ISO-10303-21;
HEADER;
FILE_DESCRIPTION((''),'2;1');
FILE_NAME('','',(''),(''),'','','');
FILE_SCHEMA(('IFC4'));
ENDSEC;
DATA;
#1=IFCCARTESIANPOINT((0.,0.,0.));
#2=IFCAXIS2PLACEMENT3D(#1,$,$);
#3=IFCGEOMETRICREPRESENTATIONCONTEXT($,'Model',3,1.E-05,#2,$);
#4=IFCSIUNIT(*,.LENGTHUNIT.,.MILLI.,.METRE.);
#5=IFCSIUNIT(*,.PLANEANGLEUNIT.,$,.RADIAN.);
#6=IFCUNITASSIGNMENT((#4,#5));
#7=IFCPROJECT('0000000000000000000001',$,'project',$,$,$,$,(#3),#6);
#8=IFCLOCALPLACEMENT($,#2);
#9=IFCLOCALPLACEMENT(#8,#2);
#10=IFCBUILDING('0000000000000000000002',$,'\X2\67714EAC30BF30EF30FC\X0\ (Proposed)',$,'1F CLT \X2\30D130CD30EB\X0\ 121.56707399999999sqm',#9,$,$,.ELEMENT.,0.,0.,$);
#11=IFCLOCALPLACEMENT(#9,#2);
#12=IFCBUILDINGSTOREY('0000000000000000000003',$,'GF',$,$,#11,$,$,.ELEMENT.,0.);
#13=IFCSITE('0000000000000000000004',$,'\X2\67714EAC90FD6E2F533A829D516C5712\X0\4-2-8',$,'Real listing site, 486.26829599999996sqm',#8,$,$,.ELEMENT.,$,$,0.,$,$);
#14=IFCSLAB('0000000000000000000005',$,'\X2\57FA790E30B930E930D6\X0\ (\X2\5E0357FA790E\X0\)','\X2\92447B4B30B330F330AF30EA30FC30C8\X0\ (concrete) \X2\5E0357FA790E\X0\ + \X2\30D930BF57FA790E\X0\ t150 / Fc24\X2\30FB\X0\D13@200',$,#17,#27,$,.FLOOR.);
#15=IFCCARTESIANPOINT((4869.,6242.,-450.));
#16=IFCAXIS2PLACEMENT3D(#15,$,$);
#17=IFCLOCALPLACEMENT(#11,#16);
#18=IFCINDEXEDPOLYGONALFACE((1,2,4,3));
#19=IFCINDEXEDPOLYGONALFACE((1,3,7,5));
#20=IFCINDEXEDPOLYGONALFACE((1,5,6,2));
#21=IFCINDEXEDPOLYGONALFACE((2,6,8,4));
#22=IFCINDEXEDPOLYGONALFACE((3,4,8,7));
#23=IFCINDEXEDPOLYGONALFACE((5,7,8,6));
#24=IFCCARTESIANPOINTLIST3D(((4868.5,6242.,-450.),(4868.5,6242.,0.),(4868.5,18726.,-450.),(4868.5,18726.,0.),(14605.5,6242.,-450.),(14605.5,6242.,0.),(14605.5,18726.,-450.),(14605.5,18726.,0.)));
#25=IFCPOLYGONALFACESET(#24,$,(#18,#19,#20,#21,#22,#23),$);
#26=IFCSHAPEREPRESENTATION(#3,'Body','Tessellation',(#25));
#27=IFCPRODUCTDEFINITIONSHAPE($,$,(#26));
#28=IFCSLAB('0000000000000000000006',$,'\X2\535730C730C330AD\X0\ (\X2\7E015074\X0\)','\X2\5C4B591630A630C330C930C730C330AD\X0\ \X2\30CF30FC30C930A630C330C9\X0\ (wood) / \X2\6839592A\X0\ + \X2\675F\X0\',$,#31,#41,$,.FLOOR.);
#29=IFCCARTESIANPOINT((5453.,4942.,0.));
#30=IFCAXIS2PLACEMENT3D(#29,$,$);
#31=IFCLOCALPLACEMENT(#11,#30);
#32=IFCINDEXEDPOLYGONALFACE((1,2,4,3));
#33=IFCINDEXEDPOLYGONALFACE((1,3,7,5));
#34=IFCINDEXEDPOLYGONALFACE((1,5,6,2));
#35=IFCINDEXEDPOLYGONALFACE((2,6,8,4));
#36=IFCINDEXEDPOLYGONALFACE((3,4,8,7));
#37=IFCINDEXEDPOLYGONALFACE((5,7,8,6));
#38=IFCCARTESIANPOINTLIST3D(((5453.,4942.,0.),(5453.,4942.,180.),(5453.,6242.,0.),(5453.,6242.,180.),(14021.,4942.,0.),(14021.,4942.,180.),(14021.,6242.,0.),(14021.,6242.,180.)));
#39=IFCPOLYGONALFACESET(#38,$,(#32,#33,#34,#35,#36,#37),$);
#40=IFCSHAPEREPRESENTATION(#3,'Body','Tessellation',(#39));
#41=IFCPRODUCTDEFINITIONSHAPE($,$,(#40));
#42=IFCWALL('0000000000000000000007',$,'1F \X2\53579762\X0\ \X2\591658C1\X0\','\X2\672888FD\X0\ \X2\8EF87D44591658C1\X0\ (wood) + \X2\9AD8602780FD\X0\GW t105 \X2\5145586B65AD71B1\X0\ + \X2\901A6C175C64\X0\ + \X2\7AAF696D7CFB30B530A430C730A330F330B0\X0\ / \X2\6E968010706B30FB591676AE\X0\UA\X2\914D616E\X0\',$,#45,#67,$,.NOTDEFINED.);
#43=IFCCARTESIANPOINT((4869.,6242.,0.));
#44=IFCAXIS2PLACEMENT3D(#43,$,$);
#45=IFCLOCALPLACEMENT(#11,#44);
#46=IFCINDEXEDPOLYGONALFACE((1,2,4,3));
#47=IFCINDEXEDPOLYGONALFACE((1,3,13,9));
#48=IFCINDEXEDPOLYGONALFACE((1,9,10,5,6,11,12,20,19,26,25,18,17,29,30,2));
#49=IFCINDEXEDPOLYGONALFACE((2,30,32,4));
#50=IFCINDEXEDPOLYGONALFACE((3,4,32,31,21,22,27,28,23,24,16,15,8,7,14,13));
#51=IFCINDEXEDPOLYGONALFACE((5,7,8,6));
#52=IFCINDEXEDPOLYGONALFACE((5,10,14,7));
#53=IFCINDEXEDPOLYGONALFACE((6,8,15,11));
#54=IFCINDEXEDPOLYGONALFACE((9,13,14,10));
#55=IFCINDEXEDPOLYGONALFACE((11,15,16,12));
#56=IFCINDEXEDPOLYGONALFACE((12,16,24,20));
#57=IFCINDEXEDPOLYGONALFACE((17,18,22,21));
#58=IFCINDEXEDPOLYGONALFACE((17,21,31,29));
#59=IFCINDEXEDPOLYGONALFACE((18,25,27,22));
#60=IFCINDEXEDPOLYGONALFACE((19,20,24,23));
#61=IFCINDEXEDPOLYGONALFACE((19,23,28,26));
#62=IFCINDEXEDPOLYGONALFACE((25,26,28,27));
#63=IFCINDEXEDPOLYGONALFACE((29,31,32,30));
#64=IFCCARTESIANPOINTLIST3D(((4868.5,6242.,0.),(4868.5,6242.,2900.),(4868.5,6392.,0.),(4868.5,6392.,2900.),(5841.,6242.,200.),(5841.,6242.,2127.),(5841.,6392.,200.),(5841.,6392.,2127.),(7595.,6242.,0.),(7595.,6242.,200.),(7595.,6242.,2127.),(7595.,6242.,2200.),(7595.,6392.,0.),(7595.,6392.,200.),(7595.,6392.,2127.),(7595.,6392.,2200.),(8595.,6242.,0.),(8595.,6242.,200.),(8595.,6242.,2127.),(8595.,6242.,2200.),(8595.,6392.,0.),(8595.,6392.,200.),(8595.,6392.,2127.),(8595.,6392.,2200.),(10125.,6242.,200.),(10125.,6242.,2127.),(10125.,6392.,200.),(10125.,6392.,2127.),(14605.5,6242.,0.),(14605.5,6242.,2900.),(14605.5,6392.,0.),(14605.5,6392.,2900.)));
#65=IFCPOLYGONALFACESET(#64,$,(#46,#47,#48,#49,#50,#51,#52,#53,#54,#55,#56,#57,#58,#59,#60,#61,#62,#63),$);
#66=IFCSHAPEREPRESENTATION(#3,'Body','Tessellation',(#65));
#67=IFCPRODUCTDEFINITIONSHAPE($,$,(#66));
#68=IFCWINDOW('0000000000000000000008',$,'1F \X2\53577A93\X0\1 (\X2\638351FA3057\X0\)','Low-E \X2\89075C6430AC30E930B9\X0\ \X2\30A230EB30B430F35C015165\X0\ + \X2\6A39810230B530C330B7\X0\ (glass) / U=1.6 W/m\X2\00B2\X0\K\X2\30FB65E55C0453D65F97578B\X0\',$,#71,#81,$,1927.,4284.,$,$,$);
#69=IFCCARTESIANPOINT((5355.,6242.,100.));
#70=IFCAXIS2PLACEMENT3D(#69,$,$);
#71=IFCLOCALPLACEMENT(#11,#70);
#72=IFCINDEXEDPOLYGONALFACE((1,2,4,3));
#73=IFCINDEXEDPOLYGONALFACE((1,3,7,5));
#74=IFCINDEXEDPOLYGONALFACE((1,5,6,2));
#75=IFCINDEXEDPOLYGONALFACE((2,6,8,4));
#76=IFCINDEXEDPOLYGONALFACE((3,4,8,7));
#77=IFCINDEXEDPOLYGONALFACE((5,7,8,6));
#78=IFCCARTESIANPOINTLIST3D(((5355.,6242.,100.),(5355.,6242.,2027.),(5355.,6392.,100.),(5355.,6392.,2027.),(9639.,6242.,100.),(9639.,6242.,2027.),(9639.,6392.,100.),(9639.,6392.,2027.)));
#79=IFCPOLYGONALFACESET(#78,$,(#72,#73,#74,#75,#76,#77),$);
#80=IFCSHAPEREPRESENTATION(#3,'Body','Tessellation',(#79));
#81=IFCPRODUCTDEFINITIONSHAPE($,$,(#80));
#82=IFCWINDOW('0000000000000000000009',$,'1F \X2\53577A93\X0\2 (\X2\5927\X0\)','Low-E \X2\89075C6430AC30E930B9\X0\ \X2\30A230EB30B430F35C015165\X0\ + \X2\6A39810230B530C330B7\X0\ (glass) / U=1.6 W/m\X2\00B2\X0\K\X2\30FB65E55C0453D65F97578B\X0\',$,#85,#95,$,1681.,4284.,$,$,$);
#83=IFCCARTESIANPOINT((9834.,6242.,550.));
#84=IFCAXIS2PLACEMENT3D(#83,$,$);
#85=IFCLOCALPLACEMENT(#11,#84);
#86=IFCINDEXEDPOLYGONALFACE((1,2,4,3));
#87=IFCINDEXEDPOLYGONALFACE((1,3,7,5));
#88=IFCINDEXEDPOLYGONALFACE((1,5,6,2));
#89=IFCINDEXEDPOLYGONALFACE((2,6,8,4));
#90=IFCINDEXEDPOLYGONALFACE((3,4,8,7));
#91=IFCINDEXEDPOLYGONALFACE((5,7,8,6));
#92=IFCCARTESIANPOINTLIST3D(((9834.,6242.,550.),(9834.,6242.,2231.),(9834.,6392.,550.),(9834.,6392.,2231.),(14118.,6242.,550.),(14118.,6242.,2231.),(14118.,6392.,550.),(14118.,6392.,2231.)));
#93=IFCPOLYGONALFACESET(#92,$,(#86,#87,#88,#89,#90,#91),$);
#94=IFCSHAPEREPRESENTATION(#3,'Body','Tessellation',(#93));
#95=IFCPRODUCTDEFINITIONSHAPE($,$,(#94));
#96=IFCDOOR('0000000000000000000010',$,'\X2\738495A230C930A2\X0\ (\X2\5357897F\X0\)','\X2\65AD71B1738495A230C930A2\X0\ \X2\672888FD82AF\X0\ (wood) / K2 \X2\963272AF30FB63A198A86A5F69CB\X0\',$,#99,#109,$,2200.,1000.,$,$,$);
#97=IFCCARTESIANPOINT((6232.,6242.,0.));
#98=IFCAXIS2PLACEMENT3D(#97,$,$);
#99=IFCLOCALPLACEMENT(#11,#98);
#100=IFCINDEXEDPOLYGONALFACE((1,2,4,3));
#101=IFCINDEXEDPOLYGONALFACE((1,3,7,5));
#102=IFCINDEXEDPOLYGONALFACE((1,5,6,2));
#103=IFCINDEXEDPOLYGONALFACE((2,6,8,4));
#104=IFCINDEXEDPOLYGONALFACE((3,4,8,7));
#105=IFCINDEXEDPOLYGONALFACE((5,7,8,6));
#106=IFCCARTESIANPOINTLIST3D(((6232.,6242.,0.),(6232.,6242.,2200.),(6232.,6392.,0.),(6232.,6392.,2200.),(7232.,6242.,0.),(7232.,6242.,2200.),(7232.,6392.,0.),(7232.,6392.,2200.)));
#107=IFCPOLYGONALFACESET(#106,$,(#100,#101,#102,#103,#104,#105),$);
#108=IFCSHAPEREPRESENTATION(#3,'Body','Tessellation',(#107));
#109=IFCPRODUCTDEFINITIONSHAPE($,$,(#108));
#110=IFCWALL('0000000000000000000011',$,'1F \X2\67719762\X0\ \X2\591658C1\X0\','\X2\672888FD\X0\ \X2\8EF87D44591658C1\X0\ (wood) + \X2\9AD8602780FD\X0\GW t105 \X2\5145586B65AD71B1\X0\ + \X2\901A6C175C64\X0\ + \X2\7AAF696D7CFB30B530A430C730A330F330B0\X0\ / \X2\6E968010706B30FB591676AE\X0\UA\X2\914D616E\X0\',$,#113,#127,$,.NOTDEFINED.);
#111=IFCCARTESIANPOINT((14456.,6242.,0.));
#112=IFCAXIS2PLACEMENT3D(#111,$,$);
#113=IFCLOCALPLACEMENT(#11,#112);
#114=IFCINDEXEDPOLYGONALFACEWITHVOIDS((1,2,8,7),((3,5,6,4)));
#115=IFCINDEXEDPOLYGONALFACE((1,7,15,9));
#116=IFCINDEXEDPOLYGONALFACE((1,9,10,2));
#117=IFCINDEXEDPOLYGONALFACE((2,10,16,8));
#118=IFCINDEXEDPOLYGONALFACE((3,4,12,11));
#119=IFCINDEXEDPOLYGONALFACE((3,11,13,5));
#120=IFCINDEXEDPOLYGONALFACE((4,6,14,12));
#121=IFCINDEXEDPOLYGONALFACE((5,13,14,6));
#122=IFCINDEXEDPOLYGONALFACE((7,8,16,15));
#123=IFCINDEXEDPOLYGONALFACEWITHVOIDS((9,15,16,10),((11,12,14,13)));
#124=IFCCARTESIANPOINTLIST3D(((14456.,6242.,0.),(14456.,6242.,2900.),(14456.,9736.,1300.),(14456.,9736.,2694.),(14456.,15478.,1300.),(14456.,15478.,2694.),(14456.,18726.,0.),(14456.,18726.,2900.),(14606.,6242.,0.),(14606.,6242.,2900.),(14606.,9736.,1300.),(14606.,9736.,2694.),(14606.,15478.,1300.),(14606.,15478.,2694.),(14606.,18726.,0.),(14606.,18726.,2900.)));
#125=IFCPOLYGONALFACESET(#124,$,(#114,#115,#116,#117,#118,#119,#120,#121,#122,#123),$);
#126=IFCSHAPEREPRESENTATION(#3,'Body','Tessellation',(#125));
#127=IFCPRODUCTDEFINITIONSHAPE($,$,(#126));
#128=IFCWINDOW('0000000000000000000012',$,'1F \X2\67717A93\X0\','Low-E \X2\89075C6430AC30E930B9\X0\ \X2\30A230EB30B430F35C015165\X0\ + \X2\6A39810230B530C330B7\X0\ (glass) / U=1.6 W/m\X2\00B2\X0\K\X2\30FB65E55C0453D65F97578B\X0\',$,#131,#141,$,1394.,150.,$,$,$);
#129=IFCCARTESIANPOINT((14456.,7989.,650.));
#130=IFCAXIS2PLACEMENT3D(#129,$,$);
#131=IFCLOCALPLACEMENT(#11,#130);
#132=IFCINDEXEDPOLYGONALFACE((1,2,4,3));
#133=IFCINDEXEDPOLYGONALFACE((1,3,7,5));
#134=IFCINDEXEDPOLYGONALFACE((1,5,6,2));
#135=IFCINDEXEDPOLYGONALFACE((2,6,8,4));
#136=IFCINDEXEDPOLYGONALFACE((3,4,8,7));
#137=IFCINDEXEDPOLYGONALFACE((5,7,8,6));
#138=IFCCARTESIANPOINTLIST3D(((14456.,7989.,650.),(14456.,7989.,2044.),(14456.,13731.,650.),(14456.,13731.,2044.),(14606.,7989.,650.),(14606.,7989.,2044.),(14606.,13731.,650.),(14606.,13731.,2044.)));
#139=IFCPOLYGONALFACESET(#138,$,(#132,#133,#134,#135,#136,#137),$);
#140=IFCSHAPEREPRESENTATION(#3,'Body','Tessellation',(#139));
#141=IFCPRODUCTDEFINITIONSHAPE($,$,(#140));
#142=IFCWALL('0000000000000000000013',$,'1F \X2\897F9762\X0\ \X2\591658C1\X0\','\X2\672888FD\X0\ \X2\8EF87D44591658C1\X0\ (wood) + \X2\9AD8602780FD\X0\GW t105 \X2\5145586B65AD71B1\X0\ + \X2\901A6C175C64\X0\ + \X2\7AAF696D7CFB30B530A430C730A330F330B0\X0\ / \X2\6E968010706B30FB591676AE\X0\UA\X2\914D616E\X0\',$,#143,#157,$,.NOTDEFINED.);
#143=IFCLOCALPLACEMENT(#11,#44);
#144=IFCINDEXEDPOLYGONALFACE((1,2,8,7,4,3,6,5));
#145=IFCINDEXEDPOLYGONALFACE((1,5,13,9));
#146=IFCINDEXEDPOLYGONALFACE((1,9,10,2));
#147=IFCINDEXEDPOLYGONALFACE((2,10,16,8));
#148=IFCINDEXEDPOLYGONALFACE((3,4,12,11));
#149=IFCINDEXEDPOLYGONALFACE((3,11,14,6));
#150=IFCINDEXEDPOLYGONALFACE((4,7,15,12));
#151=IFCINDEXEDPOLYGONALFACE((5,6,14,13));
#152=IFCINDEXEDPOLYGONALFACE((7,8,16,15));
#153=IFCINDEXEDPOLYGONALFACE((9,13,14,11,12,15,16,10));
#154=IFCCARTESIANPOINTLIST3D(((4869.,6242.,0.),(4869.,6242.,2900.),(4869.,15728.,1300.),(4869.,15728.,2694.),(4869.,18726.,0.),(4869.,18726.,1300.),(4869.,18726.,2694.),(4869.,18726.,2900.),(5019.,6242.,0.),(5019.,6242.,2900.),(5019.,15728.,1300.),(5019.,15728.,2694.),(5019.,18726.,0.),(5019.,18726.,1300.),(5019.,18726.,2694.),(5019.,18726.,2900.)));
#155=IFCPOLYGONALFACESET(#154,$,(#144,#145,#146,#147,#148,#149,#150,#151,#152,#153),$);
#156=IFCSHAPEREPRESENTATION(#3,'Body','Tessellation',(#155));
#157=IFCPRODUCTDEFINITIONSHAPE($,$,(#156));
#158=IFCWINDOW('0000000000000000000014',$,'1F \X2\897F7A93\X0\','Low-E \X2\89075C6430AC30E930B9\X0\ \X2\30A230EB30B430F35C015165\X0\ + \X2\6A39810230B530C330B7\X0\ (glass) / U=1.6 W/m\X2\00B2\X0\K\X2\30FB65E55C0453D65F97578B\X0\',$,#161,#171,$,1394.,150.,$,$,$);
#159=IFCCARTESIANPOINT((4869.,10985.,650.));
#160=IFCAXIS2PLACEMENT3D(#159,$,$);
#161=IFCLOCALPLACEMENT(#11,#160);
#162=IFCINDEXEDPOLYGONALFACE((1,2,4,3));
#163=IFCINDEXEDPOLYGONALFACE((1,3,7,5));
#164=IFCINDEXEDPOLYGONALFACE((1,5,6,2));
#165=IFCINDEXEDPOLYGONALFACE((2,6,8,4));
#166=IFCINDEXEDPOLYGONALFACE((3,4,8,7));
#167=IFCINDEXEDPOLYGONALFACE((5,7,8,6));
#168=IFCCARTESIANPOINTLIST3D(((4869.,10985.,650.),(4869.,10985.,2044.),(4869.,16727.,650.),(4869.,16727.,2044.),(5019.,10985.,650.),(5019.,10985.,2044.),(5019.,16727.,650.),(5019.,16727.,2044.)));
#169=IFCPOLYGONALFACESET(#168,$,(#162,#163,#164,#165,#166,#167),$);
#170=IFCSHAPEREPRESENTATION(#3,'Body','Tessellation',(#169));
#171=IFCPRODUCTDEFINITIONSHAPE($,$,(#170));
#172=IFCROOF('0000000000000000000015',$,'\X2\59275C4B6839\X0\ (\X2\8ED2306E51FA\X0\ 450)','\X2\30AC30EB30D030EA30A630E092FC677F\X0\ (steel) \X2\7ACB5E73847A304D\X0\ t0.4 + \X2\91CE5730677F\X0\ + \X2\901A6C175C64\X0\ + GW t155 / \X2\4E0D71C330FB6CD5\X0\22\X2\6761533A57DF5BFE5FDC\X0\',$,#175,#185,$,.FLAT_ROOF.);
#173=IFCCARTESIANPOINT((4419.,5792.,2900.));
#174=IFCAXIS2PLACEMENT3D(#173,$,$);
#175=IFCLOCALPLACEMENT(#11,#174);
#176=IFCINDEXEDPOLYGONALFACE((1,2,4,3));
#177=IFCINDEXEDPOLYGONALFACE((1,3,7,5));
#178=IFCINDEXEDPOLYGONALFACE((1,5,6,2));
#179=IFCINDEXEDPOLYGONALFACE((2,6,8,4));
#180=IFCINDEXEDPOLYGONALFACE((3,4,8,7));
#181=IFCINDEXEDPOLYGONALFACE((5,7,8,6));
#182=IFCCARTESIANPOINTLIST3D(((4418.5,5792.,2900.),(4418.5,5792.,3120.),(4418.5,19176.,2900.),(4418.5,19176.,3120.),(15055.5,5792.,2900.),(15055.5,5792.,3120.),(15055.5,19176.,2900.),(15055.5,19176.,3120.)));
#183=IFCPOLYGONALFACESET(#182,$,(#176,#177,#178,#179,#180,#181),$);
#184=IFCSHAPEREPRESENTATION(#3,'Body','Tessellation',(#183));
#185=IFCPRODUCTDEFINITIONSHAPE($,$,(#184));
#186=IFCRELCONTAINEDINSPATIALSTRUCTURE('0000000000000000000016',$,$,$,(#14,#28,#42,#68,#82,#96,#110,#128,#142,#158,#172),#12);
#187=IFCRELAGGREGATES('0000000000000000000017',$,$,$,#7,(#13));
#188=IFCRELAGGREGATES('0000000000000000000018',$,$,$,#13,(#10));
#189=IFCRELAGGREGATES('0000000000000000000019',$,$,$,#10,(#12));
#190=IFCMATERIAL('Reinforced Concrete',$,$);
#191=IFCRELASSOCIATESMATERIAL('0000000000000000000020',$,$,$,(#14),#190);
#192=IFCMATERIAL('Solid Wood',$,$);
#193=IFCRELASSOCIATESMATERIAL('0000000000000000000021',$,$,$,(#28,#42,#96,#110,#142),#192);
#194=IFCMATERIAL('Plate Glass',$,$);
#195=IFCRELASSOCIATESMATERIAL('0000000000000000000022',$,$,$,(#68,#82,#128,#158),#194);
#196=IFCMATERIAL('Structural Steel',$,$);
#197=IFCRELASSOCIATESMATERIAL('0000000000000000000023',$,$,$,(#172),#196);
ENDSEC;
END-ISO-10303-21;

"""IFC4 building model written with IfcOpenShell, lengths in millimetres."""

from ifc_helpers import new_model, si_unit, frame, frame_2d, origin, place, context, project, spatial, rectangle, extrude, material, element, fill, save


model = new_model("IFC4")

# Units and contexts
model_context = context("Model", 3, precision=1e-05, world=origin())
ifc_project = project(units=[si_unit("LENGTHUNIT", "METRE", prefix="MILLI"), si_unit("PLANEANGLEUNIT", "RADIAN")], contexts=[model_context])

# Site, building, storey
site_placement = place(None, origin())
site = spatial("IfcSite", under=ifc_project, at=site_placement, Name="東京都港区芝公園4-2-8", ObjectType="Real listing site, 486.26829599999996sqm", CompositionType="ELEMENT", RefElevation=0.0)
building_placement = place(site_placement, origin())
building = spatial("IfcBuilding", under=site, at=building_placement, Name="東京タワー (Proposed)", ObjectType="1F CLT パネル 121.56707399999999sqm", CompositionType="ELEMENT", ElevationOfRefHeight=0.0, ElevationOfTerrain=0.0)
storey_placement = place(building_placement, origin())
storey = spatial("IfcBuildingStorey", under=building, at=storey_placement, Name="GF", CompositionType="ELEMENT", Elevation=0.0)

# Slabs
ifc_material_1 = material(Name="Reinforced Concrete")
slab_1_placement = place(storey_placement, frame((4869.0, 6242.0, -450.0)))
element("IfcSlab", 1, at=slab_1_placement, inside=storey, material=ifc_material_1, Name="基礎スラブ (布基礎)", Description="鉄筋コンクリート (concrete) 布基礎 + ベタ基礎 t150 / Fc24・D13@200", PredefinedType="FLOOR", context=model_context, shape_type="SweptSolid", body=[
    extrude(rectangle(XDim=9737.0, YDim=12484.0, at=frame_2d((4868.0, 6242.0))), frame((4869.0, 6242.0, -450.0)), (0.0, 0.0, 1.0), 450.0),
])
ifc_material_2 = material(Name="Solid Wood")
slab_2_placement = place(storey_placement, frame((5453.0, 4942.0, 0.0)))
element("IfcSlab", 2, at=slab_2_placement, inside=storey, material=ifc_material_2, Name="南デッキ (縁側)", Description="屋外ウッドデッキ ハードウッド (wood) / 根太 + 束", PredefinedType="FLOOR", context=model_context, shape_type="SweptSolid", body=[
    extrude(rectangle(XDim=8568.0, YDim=1300.0, at=frame_2d((4284.0, 650.0))), frame((5453.0, 4942.0, 0.0)), (0.0, 0.0, 1.0), 180.0),
])

# Wall, openings, windows, door
wall_1_placement = place(storey_placement, frame((4869.0, 6242.0, 0.0)))
wall_1 = element("IfcWall", 3, at=wall_1_placement, inside=storey, material=ifc_material_2, Name="1F 南面 外壁", Description="木製 軸組外壁 (wood) + 高性能GW t105 充填断熱 + 通気層 + 窯業系サイディング / 準耐火・外皮UA配慮", PredefinedType="NOTDEFINED", context=model_context, shape_type="SweptSolid", body=[
    extrude(rectangle(XDim=9737.0, YDim=150.0, at=frame_2d((4868.0, 75.0))), frame((4869.0, 6242.0, 0.0)), (0.0, 0.0, 1.0), 2900.0),
])
opening_1_placement = place(storey_placement, frame((5355.0, 6242.0, 100.0)))
opening_1 = element("IfcOpeningElement", 4, at=opening_1_placement, cuts=wall_1, PredefinedType="NOTDEFINED", context=model_context, shape_type="SweptSolid", body=[
    extrude(rectangle(XDim=4284.0, YDim=150.0, at=frame_2d((2142.0, 75.0))), frame((5355.0, 6242.0, 100.0)), (0.0, 0.0, 1.0), 1927.0),
])
opening_2_placement = place(storey_placement, frame((9834.0, 6242.0, 550.0)))
opening_2 = element("IfcOpeningElement", 5, at=opening_2_placement, cuts=wall_1, PredefinedType="NOTDEFINED", context=model_context, shape_type="SweptSolid", body=[
    extrude(rectangle(XDim=4284.0, YDim=150.0, at=frame_2d((2142.0, 75.0))), frame((9834.0, 6242.0, 550.0)), (0.0, 0.0, 1.0), 1681.0),
])
opening_3_placement = place(storey_placement, frame((6232.0, 6242.0, 0.0)))
opening_3 = element("IfcOpeningElement", 6, at=opening_3_placement, cuts=wall_1, PredefinedType="NOTDEFINED", context=model_context, shape_type="SweptSolid", body=[
    extrude(rectangle(XDim=1000.0, YDim=150.0, at=frame_2d((500.0, 75.0))), frame((6232.0, 6242.0, 0.0)), (0.0, 0.0, 1.0), 2200.0),
])
ifc_material_3 = material(Name="Plate Glass")
window_1_placement = place(storey_placement, frame((5355.0, 6242.0, 100.0)))
window_1 = element("IfcWindow", 7, at=window_1_placement, inside=storey, material=ifc_material_3, Name="1F 南窓1 (掃出し)", Description="Low-E 複層ガラス アルゴン封入 + 樹脂サッシ (glass) / U=1.6 W/m²K・日射取得型", OverallHeight=1927.0, OverallWidth=4284.0, context=model_context, shape_type="SweptSolid", body=[
    extrude(rectangle(XDim=4284.0, YDim=150.0, at=frame_2d((2142.0, 75.0))), frame((5355.0, 6242.0, 100.0)), (0.0, 0.0, 1.0), 1927.0),
])
fill(opening_1, window_1)
window_2_placement = place(storey_placement, frame((9834.0, 6242.0, 550.0)))
window_2 = element("IfcWindow", 8, at=window_2_placement, inside=storey, material=ifc_material_3, Name="1F 南窓2 (大)", Description="Low-E 複層ガラス アルゴン封入 + 樹脂サッシ (glass) / U=1.6 W/m²K・日射取得型", OverallHeight=1681.0, OverallWidth=4284.0, context=model_context, shape_type="SweptSolid", body=[
    extrude(rectangle(XDim=4284.0, YDim=150.0, at=frame_2d((2142.0, 75.0))), frame((9834.0, 6242.0, 550.0)), (0.0, 0.0, 1.0), 1681.0),
])
fill(opening_2, window_2)
door_placement = place(storey_placement, frame((6232.0, 6242.0, 0.0)))
door = element("IfcDoor", 9, at=door_placement, inside=storey, material=ifc_material_2, Name="玄関ドア (南西)", Description="断熱玄関ドア 木製芯 (wood) / K2 防犯・採風機構", OverallHeight=2200.0, OverallWidth=1000.0, context=model_context, shape_type="SweptSolid", body=[
    extrude(rectangle(XDim=1000.0, YDim=150.0, at=frame_2d((500.0, 75.0))), frame((6232.0, 6242.0, 0.0)), (0.0, 0.0, 1.0), 2200.0),
])
fill(opening_3, door)

# Walls, openings, windows
wall_2_placement = place(storey_placement, frame((14456.0, 6242.0, 0.0)))
wall_2 = element("IfcWall", 10, at=wall_2_placement, inside=storey, material=ifc_material_2, Name="1F 東面 外壁", Description="木製 軸組外壁 (wood) + 高性能GW t105 充填断熱 + 通気層 + 窯業系サイディング / 準耐火・外皮UA配慮", PredefinedType="NOTDEFINED", context=model_context, shape_type="SweptSolid", body=[
    extrude(rectangle(XDim=150.0, YDim=12484.0, at=frame_2d((75.0, 6242.0))), frame((14456.0, 6242.0, 0.0)), (0.0, 0.0, 1.0), 2900.0),
])
opening_4_placement = place(storey_placement, frame((14456.0, 7989.0, 650.0)))
opening_4 = element("IfcOpeningElement", 11, at=opening_4_placement, cuts=wall_2, PredefinedType="NOTDEFINED", context=model_context, shape_type="SweptSolid", body=[
    extrude(rectangle(XDim=150.0, YDim=5742.0, at=frame_2d((75.0, 2871.0))), frame((14456.0, 7989.0, 650.0)), (0.0, 0.0, 1.0), 1394.0),
])
window_3_placement = place(storey_placement, frame((14456.0, 7989.0, 650.0)))
window_3 = element("IfcWindow", 12, at=window_3_placement, inside=storey, material=ifc_material_3, Name="1F 東窓", Description="Low-E 複層ガラス アルゴン封入 + 樹脂サッシ (glass) / U=1.6 W/m²K・日射取得型", OverallHeight=1394.0, OverallWidth=150.0, context=model_context, shape_type="SweptSolid", body=[
    extrude(rectangle(XDim=150.0, YDim=5742.0, at=frame_2d((75.0, 2871.0))), frame((14456.0, 7989.0, 650.0)), (0.0, 0.0, 1.0), 1394.0),
])
fill(opening_4, window_3)
wall_3_placement = place(storey_placement, frame((4869.0, 6242.0, 0.0)))
wall_3 = element("IfcWall", 13, at=wall_3_placement, inside=storey, material=ifc_material_2, Name="1F 西面 外壁", Description="木製 軸組外壁 (wood) + 高性能GW t105 充填断熱 + 通気層 + 窯業系サイディング / 準耐火・外皮UA配慮", PredefinedType="NOTDEFINED", context=model_context, shape_type="SweptSolid", body=[
    extrude(rectangle(XDim=150.0, YDim=12484.0, at=frame_2d((75.0, 6242.0))), frame((4869.0, 6242.0, 0.0)), (0.0, 0.0, 1.0), 2900.0),
])
opening_5_placement = place(storey_placement, frame((4869.0, 10985.0, 650.0)))
opening_5 = element("IfcOpeningElement", 14, at=opening_5_placement, cuts=wall_3, PredefinedType="NOTDEFINED", context=model_context, shape_type="SweptSolid", body=[
    extrude(rectangle(XDim=150.0, YDim=5742.0, at=frame_2d((75.0, 2871.0))), frame((4869.0, 10985.0, 650.0)), (0.0, 0.0, 1.0), 1394.0),
])
window_4_placement = place(storey_placement, frame((4869.0, 10985.0, 650.0)))
window_4 = element("IfcWindow", 15, at=window_4_placement, inside=storey, material=ifc_material_3, Name="1F 西窓", Description="Low-E 複層ガラス アルゴン封入 + 樹脂サッシ (glass) / U=1.6 W/m²K・日射取得型", OverallHeight=1394.0, OverallWidth=150.0, context=model_context, shape_type="SweptSolid", body=[
    extrude(rectangle(XDim=150.0, YDim=5742.0, at=frame_2d((75.0, 2871.0))), frame((4869.0, 10985.0, 650.0)), (0.0, 0.0, 1.0), 1394.0),
])
fill(opening_5, window_4)

# Roof
ifc_material_4 = material(Name="Structural Steel")
roof_placement = place(storey_placement, frame((4419.0, 5792.0, 2900.0)))
element("IfcRoof", 16, at=roof_placement, inside=storey, material=ifc_material_4, Name="大屋根 (軒の出 450)", Description="ガルバリウム鋼板 (steel) 立平葺き t0.4 + 野地板 + 通気層 + GW t155 / 不燃・法22条区域対応", PredefinedType="FLAT_ROOF", context=model_context, shape_type="SweptSolid", body=[
    extrude(rectangle(XDim=10637.0, YDim=13384.0, at=frame_2d((5318.0, 6692.0))), frame((4419.0, 5792.0, 2900.0)), (0.0, 0.0, 1.0), 220.0),
])

save(model, "model.ifc")
